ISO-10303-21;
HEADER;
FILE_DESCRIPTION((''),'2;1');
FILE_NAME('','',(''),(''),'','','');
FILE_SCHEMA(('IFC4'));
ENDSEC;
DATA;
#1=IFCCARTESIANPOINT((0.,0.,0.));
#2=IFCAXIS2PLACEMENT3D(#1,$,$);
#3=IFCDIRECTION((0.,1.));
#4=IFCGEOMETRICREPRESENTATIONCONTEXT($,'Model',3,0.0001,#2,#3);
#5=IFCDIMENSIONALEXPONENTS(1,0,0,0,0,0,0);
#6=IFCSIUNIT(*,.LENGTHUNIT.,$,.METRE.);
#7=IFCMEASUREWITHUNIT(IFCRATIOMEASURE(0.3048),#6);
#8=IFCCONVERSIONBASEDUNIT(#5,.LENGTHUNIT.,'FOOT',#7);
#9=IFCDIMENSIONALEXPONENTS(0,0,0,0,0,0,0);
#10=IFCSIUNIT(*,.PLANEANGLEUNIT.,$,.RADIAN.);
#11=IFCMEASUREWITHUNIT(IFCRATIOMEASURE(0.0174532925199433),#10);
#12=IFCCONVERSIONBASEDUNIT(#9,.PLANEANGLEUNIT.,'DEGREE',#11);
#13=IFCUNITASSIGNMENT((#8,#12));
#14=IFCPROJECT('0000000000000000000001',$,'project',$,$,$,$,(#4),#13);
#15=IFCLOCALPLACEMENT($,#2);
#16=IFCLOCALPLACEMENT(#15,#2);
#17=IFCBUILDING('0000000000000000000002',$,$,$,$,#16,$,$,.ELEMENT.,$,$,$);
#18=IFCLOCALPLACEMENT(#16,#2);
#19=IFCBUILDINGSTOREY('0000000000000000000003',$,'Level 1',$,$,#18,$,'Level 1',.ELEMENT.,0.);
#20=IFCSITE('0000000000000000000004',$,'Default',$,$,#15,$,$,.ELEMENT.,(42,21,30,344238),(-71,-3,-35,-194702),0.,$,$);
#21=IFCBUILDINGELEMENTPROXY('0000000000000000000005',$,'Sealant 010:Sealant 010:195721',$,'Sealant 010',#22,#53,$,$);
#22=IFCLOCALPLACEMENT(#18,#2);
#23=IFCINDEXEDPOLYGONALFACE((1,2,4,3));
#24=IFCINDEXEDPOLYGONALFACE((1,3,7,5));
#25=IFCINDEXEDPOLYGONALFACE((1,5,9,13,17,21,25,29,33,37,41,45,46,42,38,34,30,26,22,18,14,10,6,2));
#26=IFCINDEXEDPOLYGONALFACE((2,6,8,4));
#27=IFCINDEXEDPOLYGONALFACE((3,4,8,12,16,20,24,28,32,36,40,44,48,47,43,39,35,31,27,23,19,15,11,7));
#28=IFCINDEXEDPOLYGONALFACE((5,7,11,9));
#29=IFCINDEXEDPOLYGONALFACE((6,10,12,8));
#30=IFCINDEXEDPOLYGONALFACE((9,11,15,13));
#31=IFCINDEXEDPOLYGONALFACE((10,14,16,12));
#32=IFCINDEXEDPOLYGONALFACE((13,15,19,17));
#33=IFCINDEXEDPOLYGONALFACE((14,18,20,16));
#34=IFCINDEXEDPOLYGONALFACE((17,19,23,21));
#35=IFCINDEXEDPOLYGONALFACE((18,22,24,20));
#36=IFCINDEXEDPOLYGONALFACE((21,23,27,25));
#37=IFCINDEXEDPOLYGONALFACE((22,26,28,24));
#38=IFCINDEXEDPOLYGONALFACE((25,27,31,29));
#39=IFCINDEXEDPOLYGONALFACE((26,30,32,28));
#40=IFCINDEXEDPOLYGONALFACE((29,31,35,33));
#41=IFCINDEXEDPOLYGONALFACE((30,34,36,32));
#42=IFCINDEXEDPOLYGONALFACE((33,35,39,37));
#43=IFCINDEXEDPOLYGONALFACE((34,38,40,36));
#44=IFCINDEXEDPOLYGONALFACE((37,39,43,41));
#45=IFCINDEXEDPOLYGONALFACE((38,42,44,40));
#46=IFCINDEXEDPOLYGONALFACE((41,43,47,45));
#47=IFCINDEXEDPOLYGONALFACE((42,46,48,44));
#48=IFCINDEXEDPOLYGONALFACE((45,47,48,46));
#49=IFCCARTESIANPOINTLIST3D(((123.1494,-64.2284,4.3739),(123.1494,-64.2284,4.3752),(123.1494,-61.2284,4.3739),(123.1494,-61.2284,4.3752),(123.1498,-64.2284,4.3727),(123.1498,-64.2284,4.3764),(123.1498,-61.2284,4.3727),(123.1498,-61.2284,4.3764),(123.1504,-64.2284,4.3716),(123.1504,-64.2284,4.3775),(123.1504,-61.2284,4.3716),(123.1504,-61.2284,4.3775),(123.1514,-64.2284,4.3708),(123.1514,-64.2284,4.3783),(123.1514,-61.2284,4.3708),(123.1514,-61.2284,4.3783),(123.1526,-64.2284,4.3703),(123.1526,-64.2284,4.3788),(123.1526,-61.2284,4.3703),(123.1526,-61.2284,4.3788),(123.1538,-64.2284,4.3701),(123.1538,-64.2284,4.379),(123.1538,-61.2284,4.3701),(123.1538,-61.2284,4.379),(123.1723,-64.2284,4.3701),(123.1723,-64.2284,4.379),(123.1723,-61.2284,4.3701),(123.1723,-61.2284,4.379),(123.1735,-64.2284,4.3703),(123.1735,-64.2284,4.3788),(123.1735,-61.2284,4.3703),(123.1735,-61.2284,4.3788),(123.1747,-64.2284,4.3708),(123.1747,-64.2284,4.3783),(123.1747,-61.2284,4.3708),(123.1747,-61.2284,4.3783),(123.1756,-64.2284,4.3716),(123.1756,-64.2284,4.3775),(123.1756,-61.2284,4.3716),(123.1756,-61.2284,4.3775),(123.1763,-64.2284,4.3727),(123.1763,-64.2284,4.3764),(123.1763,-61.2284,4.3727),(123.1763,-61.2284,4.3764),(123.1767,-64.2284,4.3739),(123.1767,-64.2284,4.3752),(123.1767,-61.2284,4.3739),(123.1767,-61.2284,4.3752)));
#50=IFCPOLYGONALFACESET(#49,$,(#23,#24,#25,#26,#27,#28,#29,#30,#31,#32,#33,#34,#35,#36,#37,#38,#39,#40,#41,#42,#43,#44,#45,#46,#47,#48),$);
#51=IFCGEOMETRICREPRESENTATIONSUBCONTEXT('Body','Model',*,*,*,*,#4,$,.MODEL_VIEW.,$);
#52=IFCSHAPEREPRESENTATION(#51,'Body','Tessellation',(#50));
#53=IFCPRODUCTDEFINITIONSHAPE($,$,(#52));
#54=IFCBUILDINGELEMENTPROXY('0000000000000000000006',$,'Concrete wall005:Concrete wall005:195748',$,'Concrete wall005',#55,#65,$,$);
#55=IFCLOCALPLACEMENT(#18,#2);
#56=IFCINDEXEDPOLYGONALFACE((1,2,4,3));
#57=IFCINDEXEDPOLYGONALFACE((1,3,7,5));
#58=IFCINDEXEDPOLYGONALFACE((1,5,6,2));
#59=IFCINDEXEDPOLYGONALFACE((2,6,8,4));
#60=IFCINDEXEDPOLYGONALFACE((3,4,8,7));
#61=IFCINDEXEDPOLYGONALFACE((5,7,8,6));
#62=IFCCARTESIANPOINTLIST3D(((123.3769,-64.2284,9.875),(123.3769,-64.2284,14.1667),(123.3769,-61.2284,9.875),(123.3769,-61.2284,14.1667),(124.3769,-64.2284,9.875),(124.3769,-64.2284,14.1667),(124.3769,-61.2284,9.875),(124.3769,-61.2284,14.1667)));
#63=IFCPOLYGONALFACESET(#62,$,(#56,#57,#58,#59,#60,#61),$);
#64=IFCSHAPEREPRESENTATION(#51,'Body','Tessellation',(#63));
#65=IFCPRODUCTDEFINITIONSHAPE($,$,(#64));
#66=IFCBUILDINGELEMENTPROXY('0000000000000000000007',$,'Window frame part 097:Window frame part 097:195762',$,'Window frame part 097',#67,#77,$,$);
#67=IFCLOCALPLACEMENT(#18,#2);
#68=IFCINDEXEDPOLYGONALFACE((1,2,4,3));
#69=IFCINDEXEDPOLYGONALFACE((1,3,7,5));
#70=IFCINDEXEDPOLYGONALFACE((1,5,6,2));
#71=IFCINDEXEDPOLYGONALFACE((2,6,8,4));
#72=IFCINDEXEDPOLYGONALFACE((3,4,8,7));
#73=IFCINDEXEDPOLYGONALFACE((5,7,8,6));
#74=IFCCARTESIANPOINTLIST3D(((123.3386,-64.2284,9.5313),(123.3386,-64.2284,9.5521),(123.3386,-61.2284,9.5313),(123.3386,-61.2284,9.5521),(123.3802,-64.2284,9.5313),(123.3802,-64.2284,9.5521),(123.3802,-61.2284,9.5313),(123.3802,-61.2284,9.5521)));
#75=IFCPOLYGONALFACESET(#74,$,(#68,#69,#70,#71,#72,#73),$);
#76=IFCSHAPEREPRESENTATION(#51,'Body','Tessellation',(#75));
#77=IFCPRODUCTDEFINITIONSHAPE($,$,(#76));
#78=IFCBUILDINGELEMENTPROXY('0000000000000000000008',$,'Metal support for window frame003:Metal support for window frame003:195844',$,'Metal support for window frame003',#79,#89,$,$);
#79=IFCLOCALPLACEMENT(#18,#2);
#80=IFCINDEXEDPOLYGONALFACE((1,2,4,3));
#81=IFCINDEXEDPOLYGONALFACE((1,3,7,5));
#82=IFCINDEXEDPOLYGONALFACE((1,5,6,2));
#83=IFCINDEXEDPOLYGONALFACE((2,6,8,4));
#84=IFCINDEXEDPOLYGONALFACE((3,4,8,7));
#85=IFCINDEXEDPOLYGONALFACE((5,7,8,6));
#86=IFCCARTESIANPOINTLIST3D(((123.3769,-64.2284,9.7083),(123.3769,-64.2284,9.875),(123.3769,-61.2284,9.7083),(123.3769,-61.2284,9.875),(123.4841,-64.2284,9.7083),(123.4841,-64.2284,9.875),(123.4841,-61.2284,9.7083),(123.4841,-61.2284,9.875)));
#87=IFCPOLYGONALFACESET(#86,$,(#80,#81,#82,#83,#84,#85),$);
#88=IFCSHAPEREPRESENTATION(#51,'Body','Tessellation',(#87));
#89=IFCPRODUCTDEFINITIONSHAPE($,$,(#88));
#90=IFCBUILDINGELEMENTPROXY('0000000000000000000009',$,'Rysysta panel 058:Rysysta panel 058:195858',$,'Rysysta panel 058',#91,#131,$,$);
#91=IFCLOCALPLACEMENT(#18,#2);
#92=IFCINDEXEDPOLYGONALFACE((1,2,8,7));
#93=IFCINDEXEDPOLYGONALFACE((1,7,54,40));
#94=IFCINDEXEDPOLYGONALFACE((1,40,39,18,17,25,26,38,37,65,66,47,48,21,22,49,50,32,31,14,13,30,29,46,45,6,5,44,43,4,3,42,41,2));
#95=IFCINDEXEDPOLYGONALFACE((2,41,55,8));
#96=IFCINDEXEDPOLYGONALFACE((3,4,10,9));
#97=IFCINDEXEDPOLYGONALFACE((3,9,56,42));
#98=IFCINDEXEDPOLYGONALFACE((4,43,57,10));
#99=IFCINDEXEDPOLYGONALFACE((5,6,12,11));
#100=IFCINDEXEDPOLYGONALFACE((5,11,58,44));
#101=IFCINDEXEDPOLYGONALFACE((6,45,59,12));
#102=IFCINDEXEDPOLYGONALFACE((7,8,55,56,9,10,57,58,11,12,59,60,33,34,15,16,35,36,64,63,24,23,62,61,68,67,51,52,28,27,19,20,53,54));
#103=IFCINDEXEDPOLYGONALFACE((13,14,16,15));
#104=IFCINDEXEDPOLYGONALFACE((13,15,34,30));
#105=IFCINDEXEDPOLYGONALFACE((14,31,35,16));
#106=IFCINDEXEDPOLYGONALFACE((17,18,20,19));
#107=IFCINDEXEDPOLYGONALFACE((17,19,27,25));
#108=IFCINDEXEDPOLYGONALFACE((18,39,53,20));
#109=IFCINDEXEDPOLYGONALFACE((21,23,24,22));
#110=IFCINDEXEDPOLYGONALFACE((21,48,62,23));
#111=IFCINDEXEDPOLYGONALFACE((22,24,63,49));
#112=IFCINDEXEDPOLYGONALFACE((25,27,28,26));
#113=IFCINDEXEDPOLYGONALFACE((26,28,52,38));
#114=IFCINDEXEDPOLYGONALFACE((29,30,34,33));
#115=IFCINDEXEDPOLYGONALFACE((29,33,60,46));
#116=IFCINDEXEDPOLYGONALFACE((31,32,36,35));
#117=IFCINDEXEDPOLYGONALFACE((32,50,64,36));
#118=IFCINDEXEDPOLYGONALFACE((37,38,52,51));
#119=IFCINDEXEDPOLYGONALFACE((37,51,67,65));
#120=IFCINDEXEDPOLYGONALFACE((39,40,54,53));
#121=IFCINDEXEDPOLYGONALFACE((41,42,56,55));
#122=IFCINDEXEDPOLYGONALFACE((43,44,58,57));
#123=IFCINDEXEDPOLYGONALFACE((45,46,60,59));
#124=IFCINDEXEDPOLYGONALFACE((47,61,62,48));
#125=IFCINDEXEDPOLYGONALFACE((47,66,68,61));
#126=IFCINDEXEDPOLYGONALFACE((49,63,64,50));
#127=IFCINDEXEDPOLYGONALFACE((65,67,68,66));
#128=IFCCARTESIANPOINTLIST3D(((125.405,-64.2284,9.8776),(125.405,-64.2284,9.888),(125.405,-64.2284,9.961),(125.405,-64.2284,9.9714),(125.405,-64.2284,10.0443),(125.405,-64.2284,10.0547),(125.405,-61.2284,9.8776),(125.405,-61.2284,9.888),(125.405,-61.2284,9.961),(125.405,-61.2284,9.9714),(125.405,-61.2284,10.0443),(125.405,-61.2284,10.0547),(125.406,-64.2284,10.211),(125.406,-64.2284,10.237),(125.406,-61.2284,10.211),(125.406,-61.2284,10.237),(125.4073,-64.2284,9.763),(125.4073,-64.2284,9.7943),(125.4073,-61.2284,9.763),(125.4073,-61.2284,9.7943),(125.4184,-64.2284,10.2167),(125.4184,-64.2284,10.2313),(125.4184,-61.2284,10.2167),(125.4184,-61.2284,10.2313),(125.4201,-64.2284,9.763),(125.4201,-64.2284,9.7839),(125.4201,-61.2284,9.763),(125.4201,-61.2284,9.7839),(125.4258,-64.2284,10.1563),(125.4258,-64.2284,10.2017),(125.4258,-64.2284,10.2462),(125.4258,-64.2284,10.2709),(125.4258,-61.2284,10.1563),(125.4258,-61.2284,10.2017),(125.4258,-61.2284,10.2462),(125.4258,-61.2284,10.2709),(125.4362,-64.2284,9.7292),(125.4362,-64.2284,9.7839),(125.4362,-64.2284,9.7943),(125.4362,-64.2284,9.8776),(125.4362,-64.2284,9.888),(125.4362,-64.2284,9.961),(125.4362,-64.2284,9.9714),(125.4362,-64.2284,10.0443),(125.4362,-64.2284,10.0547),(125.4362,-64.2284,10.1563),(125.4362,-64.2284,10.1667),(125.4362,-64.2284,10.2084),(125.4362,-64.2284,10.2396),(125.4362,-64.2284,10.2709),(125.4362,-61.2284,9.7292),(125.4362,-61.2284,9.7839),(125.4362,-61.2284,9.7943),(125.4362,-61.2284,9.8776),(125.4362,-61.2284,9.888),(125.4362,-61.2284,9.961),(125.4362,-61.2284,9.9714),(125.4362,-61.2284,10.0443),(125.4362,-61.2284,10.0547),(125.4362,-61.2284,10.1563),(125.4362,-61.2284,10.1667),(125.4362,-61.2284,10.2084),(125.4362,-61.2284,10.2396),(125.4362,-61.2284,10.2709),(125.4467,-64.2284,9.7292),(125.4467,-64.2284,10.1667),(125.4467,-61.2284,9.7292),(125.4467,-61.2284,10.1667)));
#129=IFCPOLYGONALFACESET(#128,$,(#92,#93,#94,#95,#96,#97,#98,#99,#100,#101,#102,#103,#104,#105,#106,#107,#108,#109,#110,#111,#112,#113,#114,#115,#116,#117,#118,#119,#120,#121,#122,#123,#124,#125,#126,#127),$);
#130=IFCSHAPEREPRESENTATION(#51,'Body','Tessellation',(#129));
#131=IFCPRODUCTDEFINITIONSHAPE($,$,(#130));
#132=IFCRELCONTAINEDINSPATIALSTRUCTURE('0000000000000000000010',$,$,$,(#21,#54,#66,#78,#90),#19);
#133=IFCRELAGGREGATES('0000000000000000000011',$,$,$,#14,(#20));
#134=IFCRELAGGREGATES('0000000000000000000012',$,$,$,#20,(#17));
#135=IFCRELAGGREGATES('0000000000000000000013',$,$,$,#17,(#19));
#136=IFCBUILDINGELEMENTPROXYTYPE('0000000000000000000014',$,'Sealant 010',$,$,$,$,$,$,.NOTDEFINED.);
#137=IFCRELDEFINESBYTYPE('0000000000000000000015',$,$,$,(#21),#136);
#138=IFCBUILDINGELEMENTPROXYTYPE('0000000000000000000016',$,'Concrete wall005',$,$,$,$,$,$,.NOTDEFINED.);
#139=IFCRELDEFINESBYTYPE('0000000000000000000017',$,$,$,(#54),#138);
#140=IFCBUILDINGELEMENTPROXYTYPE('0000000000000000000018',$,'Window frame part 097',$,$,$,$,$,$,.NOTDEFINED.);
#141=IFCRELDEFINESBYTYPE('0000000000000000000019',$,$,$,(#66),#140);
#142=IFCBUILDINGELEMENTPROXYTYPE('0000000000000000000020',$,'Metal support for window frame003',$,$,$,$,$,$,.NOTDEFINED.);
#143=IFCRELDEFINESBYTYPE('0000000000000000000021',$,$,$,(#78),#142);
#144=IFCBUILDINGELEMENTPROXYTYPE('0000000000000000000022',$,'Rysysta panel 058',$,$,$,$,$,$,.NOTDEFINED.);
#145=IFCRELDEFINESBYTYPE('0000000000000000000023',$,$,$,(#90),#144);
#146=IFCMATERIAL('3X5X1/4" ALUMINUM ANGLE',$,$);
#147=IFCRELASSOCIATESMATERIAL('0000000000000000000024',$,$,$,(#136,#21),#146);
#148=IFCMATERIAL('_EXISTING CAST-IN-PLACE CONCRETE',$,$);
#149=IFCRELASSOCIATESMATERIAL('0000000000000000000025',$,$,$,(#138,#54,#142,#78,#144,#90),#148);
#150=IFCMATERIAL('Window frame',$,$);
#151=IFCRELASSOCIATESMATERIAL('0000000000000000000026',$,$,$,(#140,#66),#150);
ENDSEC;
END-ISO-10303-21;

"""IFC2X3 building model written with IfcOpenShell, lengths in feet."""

from ifc_helpers import new_model, entity, si_unit, converted_unit, direction, frame, frame_2d, origin, origin_2d_with_axis, place, context, subcontext, project, spatial, polyline, circle_curve, parameter, trimmed, segment, composite_curve, rectangle, outline, extrude, source, transform, mapped, material, type_object, type_shapes, element, save


model = new_model("IFC2X3")

# Units and contexts
model_context = context("Model", 3, precision=0.0001, world=origin(), true_north=direction((0.0, 1.0)))
body_context = subcontext(model_context, "Body", "Model", "MODEL_VIEW")
ifc_project = project(units=[converted_unit("LENGTHUNIT", "FOOT", entity("IfcRatioMeasure", 0.3048), si_unit("LENGTHUNIT", "METRE"), dimensions=[1, 0, 0, 0, 0, 0, 0]), converted_unit("PLANEANGLEUNIT", "DEGREE", entity("IfcRatioMeasure", 0.0174532925199433), si_unit("PLANEANGLEUNIT", "RADIAN"), dimensions=[0, 0, 0, 0, 0, 0, 0])], contexts=[model_context])

# Site, building, storey
site_placement = place(None, origin())
site = spatial("IfcSite", under=ifc_project, at=site_placement, Name="Default", CompositionType="ELEMENT", RefLatitude=(42, 21, 30, 344238), RefLongitude=(-71, -3, -35, -194702), RefElevation=0.0)
building_placement = place(site_placement, origin())
building = spatial("IfcBuilding", under=site, at=building_placement, CompositionType="ELEMENT")
storey_placement = place(building_placement, origin())
storey = spatial("IfcBuildingStorey", under=building, at=storey_placement, Name="Level 1", LongName="Level 1", CompositionType="ELEMENT", Elevation=0.0)

# Building element proxies
ifc_material_1 = material(Name="3X5X1/4\" ALUMINUM ANGLE")
building_element_proxy_type_1 = type_object("IfcBuildingElementProxyType", Name="Sealant 010", PredefinedType="NOTDEFINED", material=ifc_material_1)
shared_shape_1 = source(origin(), body_context, "Body", "SweptSolid", [
    extrude(outline(composite_curve([segment(trimmed(circle_curve(frame_2d((-0.0092, 0.0), x_axis=(1.0, 0.0)), 0.0045), [parameter(90.0)], [parameter(270.0)], True, "PARAMETER"), True, "CONTINUOUS"), segment(polyline([(-0.0092, -0.0045), (0.0092, -0.0045)]), True, "CONTINUOUS"), segment(trimmed(circle_curve(frame_2d((0.0092, 0.0), x_axis=(1.0, 0.0)), 0.0045), [parameter(270.0)], [parameter(90.0)], True, "PARAMETER"), True, "CONTINUOUS"), segment(polyline([(0.0092, 0.0045), (-0.0092, 0.0045)]), True, "CONTINUOUS")], self_intersect=False)), frame((123.163, -64.2284, 4.3745), z_axis=(0.0, 1.0, 0.0), x_axis=(1.0, 0.0, 0.0)), (0.0, 0.0, 1.0), 3.0),
])
type_shapes(building_element_proxy_type_1, [shared_shape_1])
proxy_1_placement = place(storey_placement, origin())
element("IfcBuildingElementProxy", 1, at=proxy_1_placement, inside=storey, type_object=building_element_proxy_type_1, material=ifc_material_1, Name="Sealant 010:Sealant 010:195721", ObjectType="Sealant 010", context=body_context, shape_type="MappedRepresentation", body=[
    mapped(shared_shape_1, transform((0.0, 0.0, 0.0), scale=1.0)),
])
ifc_material_2 = material(Name="_EXISTING CAST-IN-PLACE CONCRETE")
building_element_proxy_type_2 = type_object("IfcBuildingElementProxyType", Name="Concrete wall005", PredefinedType="NOTDEFINED", material=ifc_material_2)
shared_shape_2 = source(origin(), body_context, "Body", "SweptSolid", [
    extrude(rectangle(XDim=3.0, YDim=1.0, at=frame_2d((0.0, 0.0), x_axis=(1.0, 0.0))), frame((123.8769, -62.7284, 9.875), z_axis=(0.0, 0.0, 1.0), x_axis=(0.0, 1.0, 0.0)), (0.0, 0.0, 1.0), 4.2917),
])
type_shapes(building_element_proxy_type_2, [shared_shape_2])
proxy_2_placement = place(storey_placement, origin())
element("IfcBuildingElementProxy", 2, at=proxy_2_placement, inside=storey, type_object=building_element_proxy_type_2, material=ifc_material_2, Name="Concrete wall005:Concrete wall005:195748", ObjectType="Concrete wall005", context=body_context, shape_type="MappedRepresentation", body=[
    mapped(shared_shape_2, transform((0.0, 0.0, 0.0), scale=1.0)),
])
ifc_material_3 = material(Name="Window frame")
building_element_proxy_type_3 = type_object("IfcBuildingElementProxyType", Name="Window frame part 097", PredefinedType="NOTDEFINED", material=ifc_material_3)
shared_shape_3 = source(origin(), body_context, "Body", "SweptSolid", [
    extrude(rectangle(XDim=3.0, YDim=0.0417, at=origin_2d_with_axis()), frame((123.3594, -62.7284, 9.5313), z_axis=(0.0, 0.0, 1.0), x_axis=(0.0, 1.0, 0.0)), (0.0, 0.0, 1.0), 0.0208),
])
type_shapes(building_element_proxy_type_3, [shared_shape_3])
proxy_3_placement = place(storey_placement, origin())
element("IfcBuildingElementProxy", 3, at=proxy_3_placement, inside=storey, type_object=building_element_proxy_type_3, material=ifc_material_3, Name="Window frame part 097:Window frame part 097:195762", ObjectType="Window frame part 097", context=body_context, shape_type="MappedRepresentation", body=[
    mapped(shared_shape_3, transform((0.0, 0.0, 0.0), scale=1.0)),
])
building_element_proxy_type_4 = type_object("IfcBuildingElementProxyType", Name="Metal support for window frame003", PredefinedType="NOTDEFINED", material=ifc_material_2)
shared_shape_4 = source(origin(), body_context, "Body", "SweptSolid", [
    extrude(rectangle(XDim=3.0, YDim=0.1073, at=frame_2d((0.0, 0.0), x_axis=(1.0, 0.0))), frame((123.4305, -62.7284, 9.7083), z_axis=(0.0, 0.0, 1.0), x_axis=(0.0, 1.0, 0.0)), (0.0, 0.0, 1.0), 0.1667),
])
type_shapes(building_element_proxy_type_4, [shared_shape_4])
proxy_4_placement = place(storey_placement, origin())
element("IfcBuildingElementProxy", 4, at=proxy_4_placement, inside=storey, type_object=building_element_proxy_type_4, material=ifc_material_2, Name="Metal support for window frame003:Metal support for window frame003:195844", ObjectType="Metal support for window frame003", context=body_context, shape_type="MappedRepresentation", body=[
    mapped(shared_shape_4, transform((0.0, 0.0, 0.0), scale=1.0)),
])
building_element_proxy_type_5 = type_object("IfcBuildingElementProxyType", Name="Rysysta panel 058", PredefinedType="NOTDEFINED", material=ifc_material_2)
shared_shape_5 = source(origin(), body_context, "Body", "SweptSolid", [
    extrude(outline(polyline([(-0.1457, -0.022), (0.2918, -0.022), (0.2918, -0.0116), (0.2371, -0.0116), (0.2371, 0.0045), (0.258, 0.0045), (0.258, 0.0173), (0.2267, 0.0173), (0.2267, -0.0116), (0.1434, -0.0116), (0.1434, 0.0196), (0.133, 0.0196), (0.133, -0.0116), (0.06, -0.0116), (0.06, 0.0196), (0.0496, 0.0196), (0.0496, -0.0116), (-0.0233, -0.0116), (-0.0233, 0.0196), (-0.0337, 0.0196), (-0.0337, -0.0116), (-0.1353, -0.0116), (-0.1353, -0.0012), (-0.1807, -0.0012), (-0.1899, 0.0186), (-0.216, 0.0186), (-0.2252, -0.0012), (-0.2498, -0.0012), (-0.2498, -0.0116), (-0.2186, -0.0116), (-0.2103, 0.0062), (-0.1956, 0.0062), (-0.1873, -0.0116), (-0.1457, -0.0116), (-0.1457, -0.022)])), frame((125.4246, -64.2284, 10.021), z_axis=(0.0, 1.0, 0.0), x_axis=(0.0, 0.0, -1.0)), (0.0, 0.0, 1.0), 3.0),
])
type_shapes(building_element_proxy_type_5, [shared_shape_5])
proxy_5_placement = place(storey_placement, origin())
element("IfcBuildingElementProxy", 5, at=proxy_5_placement, inside=storey, type_object=building_element_proxy_type_5, material=ifc_material_2, Name="Rysysta panel 058:Rysysta panel 058:195858", ObjectType="Rysysta panel 058", context=body_context, shape_type="MappedRepresentation", body=[
    mapped(shared_shape_5, transform((0.0, 0.0, 0.0), scale=1.0)),
])

save(model, "model.ifc")
